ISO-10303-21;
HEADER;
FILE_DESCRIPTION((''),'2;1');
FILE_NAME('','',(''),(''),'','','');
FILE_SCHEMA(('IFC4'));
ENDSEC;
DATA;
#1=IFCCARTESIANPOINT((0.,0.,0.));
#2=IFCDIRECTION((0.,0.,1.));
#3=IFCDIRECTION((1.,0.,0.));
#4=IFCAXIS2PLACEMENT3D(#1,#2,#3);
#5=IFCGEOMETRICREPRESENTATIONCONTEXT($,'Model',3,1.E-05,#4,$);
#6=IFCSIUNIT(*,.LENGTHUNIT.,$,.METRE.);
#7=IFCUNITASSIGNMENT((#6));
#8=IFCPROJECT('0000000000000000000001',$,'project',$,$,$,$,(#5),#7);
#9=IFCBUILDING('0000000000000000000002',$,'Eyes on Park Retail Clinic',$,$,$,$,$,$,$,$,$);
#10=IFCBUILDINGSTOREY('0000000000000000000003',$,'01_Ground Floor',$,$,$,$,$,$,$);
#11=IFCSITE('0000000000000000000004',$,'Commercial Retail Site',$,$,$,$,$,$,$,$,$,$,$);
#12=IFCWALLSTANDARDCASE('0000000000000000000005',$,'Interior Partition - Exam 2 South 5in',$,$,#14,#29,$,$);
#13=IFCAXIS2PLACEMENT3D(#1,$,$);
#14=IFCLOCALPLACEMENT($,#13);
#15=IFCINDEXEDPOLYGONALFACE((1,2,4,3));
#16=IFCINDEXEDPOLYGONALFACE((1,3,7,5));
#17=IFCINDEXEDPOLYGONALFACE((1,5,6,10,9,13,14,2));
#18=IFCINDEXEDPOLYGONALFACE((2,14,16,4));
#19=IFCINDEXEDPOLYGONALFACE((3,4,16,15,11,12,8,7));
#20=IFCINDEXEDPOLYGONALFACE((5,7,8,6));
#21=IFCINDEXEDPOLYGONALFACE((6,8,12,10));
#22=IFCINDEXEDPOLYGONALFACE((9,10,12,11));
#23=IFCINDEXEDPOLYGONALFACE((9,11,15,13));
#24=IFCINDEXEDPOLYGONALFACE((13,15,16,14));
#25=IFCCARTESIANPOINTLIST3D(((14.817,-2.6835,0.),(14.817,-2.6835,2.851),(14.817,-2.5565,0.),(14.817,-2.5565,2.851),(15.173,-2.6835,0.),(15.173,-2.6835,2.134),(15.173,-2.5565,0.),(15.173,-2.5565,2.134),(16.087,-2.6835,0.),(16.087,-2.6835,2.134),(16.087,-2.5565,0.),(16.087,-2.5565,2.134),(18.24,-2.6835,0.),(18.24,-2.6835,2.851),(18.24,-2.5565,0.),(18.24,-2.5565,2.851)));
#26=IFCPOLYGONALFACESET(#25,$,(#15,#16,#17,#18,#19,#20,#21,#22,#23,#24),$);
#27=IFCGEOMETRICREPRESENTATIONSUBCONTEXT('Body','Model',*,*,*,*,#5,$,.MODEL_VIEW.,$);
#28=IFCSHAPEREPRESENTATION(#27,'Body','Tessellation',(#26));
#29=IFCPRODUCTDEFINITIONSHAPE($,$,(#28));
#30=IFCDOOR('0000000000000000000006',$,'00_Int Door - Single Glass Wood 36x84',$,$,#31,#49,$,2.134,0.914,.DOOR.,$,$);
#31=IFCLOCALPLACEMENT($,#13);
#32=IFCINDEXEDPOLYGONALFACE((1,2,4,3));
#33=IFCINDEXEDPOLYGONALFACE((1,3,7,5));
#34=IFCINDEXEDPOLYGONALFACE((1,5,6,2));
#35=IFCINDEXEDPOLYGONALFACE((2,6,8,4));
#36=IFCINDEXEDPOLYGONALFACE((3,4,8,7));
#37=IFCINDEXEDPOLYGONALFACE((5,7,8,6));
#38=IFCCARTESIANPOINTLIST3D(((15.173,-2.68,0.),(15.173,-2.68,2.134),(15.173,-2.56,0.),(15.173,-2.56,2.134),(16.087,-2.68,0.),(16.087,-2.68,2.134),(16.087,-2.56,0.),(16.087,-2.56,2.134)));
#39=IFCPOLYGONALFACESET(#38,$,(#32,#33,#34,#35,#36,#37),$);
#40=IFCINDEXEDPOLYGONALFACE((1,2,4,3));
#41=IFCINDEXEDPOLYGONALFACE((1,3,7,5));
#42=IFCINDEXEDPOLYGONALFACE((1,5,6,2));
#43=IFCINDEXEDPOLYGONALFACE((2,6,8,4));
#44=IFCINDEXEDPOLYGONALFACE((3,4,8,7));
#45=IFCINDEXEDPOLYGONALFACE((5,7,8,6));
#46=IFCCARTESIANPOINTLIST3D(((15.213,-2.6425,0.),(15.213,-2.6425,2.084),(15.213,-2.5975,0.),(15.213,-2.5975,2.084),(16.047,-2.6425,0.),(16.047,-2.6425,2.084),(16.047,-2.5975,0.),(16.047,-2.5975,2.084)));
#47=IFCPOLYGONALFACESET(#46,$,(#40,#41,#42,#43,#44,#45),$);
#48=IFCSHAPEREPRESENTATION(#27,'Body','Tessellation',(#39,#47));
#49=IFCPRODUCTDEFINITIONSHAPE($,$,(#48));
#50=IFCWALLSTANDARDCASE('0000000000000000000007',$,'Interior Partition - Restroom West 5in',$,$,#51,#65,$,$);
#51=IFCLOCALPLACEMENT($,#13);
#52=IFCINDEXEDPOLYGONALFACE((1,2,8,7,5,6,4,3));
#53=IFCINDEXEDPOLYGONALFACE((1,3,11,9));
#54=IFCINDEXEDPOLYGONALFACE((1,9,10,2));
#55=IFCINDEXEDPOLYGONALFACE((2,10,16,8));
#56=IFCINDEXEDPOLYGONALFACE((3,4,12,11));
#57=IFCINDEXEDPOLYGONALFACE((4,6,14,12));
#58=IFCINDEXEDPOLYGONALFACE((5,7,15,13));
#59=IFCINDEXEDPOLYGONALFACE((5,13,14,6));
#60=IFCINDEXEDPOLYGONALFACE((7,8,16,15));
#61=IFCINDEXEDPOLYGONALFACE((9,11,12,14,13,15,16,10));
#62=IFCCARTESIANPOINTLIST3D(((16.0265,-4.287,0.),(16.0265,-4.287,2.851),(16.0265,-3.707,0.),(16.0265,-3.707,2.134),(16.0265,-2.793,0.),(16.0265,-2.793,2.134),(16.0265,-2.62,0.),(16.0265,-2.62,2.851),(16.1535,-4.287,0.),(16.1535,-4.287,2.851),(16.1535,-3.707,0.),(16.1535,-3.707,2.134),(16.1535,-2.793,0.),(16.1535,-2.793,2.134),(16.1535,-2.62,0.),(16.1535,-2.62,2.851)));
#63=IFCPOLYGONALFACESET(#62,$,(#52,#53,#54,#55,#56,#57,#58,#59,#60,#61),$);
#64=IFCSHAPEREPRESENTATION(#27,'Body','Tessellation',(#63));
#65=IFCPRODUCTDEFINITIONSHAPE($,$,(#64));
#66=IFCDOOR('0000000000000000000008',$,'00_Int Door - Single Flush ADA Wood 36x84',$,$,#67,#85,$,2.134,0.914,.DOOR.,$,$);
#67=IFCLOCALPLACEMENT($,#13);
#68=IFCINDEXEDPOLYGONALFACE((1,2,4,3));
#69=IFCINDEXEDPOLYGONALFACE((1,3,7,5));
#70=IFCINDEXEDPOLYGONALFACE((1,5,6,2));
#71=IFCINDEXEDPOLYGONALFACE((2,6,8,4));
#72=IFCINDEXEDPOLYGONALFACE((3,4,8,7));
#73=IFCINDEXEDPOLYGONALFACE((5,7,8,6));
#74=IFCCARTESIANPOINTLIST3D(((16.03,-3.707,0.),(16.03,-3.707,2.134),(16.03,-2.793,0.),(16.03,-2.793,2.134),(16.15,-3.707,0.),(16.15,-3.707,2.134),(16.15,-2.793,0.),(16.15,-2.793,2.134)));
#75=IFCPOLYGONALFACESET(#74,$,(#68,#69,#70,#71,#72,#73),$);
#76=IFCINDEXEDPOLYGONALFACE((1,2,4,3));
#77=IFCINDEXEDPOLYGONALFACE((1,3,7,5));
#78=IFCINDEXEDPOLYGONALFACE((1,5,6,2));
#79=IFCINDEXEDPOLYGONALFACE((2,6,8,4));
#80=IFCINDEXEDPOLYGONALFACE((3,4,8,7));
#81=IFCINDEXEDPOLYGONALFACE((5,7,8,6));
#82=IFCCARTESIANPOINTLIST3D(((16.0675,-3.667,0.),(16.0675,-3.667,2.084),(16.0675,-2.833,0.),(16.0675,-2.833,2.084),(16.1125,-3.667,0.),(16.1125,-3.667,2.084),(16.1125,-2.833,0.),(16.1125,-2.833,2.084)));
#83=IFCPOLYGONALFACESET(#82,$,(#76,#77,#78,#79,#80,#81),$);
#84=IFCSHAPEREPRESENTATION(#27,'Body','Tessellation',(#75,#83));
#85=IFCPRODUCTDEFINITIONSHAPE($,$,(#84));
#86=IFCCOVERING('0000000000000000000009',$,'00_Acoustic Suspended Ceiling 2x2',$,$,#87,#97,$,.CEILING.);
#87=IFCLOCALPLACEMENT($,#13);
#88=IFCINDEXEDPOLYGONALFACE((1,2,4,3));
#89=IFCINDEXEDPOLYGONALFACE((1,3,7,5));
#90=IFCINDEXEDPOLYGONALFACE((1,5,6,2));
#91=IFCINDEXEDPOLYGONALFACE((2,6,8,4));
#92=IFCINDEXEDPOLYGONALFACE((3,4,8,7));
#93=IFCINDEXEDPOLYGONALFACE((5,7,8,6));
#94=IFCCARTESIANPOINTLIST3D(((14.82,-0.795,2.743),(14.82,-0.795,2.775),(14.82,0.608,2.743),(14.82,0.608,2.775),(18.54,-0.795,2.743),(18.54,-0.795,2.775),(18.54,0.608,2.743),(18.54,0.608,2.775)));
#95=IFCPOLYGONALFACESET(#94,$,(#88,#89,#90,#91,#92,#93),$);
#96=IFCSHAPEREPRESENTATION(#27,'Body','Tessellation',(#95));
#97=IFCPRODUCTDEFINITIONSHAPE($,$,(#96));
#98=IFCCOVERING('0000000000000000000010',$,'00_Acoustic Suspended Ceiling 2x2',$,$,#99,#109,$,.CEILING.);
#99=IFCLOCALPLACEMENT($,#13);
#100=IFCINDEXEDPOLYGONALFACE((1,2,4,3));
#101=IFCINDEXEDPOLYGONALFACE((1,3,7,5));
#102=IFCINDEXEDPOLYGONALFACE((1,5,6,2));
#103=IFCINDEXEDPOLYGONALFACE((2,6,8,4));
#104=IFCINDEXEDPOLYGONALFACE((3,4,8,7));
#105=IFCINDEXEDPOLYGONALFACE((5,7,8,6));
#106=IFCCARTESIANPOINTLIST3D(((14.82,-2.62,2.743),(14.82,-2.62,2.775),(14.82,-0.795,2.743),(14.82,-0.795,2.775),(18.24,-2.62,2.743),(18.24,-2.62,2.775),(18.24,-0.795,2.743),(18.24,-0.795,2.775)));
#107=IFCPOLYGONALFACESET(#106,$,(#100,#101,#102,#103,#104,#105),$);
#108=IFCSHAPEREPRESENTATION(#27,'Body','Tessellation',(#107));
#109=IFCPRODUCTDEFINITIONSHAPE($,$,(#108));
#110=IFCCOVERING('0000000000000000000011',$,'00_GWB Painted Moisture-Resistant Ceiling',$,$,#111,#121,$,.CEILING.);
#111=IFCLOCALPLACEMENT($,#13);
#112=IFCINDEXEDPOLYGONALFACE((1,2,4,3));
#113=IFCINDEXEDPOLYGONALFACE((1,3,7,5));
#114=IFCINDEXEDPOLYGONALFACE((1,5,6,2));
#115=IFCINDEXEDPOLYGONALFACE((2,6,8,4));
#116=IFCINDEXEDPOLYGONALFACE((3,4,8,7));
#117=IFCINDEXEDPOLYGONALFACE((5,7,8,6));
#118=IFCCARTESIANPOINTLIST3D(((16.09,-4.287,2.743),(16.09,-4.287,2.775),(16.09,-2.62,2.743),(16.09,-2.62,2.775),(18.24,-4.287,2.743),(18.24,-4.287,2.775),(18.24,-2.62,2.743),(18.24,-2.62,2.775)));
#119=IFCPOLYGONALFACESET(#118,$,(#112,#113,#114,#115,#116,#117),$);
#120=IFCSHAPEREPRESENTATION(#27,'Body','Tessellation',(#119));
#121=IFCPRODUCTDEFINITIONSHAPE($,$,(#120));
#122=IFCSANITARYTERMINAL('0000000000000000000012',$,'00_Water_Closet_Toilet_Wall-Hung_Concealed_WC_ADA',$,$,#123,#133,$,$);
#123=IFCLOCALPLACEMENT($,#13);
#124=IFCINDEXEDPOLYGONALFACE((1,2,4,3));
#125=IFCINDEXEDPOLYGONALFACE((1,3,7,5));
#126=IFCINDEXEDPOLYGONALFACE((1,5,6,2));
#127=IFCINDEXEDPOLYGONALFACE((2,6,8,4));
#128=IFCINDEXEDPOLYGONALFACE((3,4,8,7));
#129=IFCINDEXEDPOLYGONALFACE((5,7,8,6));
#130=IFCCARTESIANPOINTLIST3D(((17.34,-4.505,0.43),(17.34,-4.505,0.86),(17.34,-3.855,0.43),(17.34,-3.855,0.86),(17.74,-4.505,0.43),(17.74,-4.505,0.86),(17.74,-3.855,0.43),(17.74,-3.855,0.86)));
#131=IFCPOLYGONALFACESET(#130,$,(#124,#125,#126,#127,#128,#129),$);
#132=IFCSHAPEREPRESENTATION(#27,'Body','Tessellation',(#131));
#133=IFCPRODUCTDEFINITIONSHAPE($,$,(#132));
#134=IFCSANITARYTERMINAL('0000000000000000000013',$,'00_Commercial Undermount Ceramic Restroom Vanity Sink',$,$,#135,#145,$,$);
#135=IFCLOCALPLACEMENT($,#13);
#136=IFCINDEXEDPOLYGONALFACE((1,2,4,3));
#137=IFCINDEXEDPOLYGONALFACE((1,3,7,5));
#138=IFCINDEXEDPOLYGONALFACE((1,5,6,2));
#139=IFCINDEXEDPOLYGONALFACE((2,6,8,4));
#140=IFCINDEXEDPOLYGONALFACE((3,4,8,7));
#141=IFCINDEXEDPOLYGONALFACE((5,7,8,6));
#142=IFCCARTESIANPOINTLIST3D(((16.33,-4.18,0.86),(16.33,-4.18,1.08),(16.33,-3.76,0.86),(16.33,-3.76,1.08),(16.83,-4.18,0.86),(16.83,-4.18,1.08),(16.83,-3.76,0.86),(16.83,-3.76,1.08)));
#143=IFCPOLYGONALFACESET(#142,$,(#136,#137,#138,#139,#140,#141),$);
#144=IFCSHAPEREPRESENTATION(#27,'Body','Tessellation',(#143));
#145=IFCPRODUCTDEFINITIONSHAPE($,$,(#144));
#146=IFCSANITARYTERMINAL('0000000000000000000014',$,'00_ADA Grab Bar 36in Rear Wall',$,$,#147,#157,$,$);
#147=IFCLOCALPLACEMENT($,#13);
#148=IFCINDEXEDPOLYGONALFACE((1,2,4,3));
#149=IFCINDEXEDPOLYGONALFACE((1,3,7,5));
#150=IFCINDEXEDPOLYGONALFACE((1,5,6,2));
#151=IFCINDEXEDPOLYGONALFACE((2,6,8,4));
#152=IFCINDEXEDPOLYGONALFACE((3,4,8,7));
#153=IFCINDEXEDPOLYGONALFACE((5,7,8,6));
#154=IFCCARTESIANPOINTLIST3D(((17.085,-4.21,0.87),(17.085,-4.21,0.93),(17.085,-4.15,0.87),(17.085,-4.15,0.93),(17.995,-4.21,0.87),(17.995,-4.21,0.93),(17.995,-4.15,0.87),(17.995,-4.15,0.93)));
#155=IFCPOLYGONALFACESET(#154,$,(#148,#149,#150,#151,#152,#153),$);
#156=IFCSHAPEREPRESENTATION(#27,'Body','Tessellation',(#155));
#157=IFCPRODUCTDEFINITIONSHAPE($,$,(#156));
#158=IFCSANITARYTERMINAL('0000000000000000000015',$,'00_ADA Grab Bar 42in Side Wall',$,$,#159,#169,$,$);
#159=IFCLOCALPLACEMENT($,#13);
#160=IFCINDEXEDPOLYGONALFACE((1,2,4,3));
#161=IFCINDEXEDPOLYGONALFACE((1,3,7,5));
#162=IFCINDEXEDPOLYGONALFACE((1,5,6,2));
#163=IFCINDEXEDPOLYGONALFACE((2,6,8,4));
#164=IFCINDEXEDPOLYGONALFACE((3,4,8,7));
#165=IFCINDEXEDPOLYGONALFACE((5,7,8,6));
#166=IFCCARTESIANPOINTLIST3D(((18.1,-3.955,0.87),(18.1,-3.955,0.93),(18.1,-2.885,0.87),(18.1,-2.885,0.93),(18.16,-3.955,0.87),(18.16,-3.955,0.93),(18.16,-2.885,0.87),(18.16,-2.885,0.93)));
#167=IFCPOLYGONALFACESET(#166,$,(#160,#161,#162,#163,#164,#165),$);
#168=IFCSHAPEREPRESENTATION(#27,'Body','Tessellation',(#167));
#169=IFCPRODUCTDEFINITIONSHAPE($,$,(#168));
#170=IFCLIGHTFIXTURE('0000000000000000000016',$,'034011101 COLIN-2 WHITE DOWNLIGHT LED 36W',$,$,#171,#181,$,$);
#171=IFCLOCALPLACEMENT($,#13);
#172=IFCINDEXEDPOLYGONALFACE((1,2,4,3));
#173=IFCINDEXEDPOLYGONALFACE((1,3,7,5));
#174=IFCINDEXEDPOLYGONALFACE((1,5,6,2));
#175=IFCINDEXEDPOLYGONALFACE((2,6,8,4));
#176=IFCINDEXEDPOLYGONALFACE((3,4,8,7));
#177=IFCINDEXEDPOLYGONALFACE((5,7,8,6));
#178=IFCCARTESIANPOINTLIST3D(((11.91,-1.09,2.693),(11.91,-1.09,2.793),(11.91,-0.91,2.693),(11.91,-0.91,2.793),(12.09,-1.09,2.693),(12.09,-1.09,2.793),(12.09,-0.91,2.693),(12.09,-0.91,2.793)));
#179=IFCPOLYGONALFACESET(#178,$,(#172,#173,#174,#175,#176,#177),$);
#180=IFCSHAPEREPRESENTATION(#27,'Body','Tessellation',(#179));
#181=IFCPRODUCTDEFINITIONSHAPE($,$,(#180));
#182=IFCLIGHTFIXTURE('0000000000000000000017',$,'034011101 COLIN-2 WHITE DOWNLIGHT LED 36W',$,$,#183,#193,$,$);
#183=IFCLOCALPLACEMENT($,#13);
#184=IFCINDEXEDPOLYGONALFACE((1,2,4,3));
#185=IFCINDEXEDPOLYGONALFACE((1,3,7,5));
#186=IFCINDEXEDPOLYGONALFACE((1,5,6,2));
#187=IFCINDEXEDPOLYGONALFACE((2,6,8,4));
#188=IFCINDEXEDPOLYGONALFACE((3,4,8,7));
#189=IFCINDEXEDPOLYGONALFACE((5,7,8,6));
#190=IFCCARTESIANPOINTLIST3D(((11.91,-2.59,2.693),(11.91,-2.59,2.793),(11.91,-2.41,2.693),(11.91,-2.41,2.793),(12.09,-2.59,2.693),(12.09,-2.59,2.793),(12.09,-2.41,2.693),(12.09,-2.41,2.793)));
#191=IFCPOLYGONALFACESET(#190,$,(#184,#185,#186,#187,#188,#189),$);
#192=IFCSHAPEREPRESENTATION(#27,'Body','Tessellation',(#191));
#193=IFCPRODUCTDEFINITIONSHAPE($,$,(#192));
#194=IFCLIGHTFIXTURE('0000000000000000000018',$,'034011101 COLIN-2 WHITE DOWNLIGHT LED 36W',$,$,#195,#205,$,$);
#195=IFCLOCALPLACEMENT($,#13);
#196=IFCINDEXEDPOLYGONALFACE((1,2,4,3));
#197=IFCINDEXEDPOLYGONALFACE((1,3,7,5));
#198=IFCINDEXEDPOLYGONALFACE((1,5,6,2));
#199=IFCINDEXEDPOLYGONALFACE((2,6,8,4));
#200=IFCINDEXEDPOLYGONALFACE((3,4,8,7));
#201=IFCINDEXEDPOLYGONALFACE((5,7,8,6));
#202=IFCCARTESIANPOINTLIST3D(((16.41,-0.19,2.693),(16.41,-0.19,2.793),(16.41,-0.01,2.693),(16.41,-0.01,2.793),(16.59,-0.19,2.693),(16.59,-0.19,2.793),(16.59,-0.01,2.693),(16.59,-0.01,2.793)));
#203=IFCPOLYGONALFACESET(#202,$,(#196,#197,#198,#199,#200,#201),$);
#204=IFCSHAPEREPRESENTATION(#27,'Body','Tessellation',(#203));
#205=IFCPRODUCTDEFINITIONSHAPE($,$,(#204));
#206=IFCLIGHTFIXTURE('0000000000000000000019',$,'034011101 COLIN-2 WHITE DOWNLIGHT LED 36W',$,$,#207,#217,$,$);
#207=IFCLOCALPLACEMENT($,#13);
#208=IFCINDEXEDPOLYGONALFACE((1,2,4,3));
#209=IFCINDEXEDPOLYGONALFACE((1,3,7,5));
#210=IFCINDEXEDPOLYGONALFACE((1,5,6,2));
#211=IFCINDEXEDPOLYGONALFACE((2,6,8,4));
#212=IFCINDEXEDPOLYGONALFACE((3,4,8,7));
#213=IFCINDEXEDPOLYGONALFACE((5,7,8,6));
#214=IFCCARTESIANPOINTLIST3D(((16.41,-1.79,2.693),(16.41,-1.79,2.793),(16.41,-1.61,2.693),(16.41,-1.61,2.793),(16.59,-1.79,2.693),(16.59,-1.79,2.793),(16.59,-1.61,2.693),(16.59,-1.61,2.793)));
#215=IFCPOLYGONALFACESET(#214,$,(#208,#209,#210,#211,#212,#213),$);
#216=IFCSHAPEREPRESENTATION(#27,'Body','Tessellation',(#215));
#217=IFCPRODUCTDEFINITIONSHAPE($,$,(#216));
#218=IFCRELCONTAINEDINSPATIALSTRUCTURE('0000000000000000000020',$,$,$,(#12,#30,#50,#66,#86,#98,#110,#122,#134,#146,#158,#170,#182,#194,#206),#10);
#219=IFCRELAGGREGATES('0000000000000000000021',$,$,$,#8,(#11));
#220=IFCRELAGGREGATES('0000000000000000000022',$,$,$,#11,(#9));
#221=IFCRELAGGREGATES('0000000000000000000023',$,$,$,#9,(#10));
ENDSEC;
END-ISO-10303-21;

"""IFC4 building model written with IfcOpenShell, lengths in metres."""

from ifc_helpers import new_model, si_unit, frame, origin, origin_with_axes, place, context, subcontext, project, spatial, rectangle, extrude, element, fill, save


model = new_model("IFC4")

# Units and contexts
model_context = context("Model", 3, precision=1e-05, world=origin_with_axes())
body_context = subcontext(model_context, "Body", "Model", "MODEL_VIEW")
ifc_project = project(units=[si_unit("LENGTHUNIT", "METRE")], contexts=[model_context])

# Site, building, storey
site = spatial("IfcSite", under=ifc_project, Name="Commercial Retail Site")
building = spatial("IfcBuilding", under=site, Name="Eyes on Park Retail Clinic")
storey = spatial("IfcBuildingStorey", under=building, Name="01_Ground Floor")

# Walls, openings, doors
wall_1_placement = place(None, frame((16.5285, -2.62, 0.0), z_axis=(0.0, 0.0, 1.0), x_axis=(1.0, 0.0, 0.0)))
wall_1 = element("IfcWallStandardCase", 1, at=wall_1_placement, inside=storey, Name="Interior Partition - Exam 2 South 5in", context=body_context, shape_type="SweptSolid", body=[
    extrude(rectangle(XDim=3.423, YDim=0.127), origin(), (0.0, 0.0, 1.0), 2.851),
])
opening_1_placement = place(None, frame((15.63, -2.62, 0.0), z_axis=(0.0, 0.0, 1.0), x_axis=(1.0, 0.0, 0.0)))
opening_1 = element("IfcOpeningElement", 2, at=opening_1_placement, cuts=wall_1, context=body_context, shape_type="SweptSolid", body=[
    extrude(rectangle(XDim=0.914, YDim=0.227), origin(), (0.0, 0.0, 1.0), 2.134),
])
door_1_placement = place(opening_1_placement, origin_with_axes())
door_1 = element("IfcDoor", 3, at=door_1_placement, inside=storey, Name="00_Int Door - Single Glass Wood 36x84", OverallHeight=2.134, OverallWidth=0.914, PredefinedType="DOOR", context=body_context, shape_type="SweptSolid", body=[
    extrude(rectangle(XDim=0.914, YDim=0.12), origin(), (0.0, 0.0, 1.0), 2.134),
    extrude(rectangle(XDim=0.834, YDim=0.045), origin(), (0.0, 0.0, 1.0), 2.084),
])
fill(opening_1, door_1)
wall_2_placement = place(None, frame((16.09, -3.4535, 0.0), z_axis=(0.0, 0.0, 1.0), x_axis=(0.0, -1.0, 0.0)))
wall_2 = element("IfcWallStandardCase", 4, at=wall_2_placement, inside=storey, Name="Interior Partition - Restroom West 5in", context=body_context, shape_type="SweptSolid", body=[
    extrude(rectangle(XDim=1.667, YDim=0.127), origin(), (0.0, 0.0, 1.0), 2.851),
])
opening_2_placement = place(None, frame((16.09, -3.25, 0.0), z_axis=(0.0, 0.0, 1.0), x_axis=(0.0, -1.0, 0.0)))
opening_2 = element("IfcOpeningElement", 5, at=opening_2_placement, cuts=wall_2, context=body_context, shape_type="SweptSolid", body=[
    extrude(rectangle(XDim=0.914, YDim=0.227), origin(), (0.0, 0.0, 1.0), 2.134),
])
door_2_placement = place(opening_2_placement, origin_with_axes())
door_2 = element("IfcDoor", 6, at=door_2_placement, inside=storey, Name="00_Int Door - Single Flush ADA Wood 36x84", OverallHeight=2.134, OverallWidth=0.914, PredefinedType="DOOR", context=body_context, shape_type="SweptSolid", body=[
    extrude(rectangle(XDim=0.914, YDim=0.12), origin(), (0.0, 0.0, 1.0), 2.134),
    extrude(rectangle(XDim=0.834, YDim=0.045), origin(), (0.0, 0.0, 1.0), 2.084),
])
fill(opening_2, door_2)

# Coverings
covering_1_placement = place(None, frame((16.68, -0.0935, 2.743), z_axis=(0.0, 0.0, 1.0), x_axis=(1.0, 0.0, 0.0)))
element("IfcCovering", 7, at=covering_1_placement, inside=storey, Name="00_Acoustic Suspended Ceiling 2x2", PredefinedType="CEILING", context=body_context, shape_type="SweptSolid", body=[
    extrude(rectangle(XDim=3.72, YDim=1.403), origin(), (0.0, 0.0, 1.0), 0.032),
])
covering_2_placement = place(None, frame((16.53, -1.7075, 2.743), z_axis=(0.0, 0.0, 1.0), x_axis=(1.0, 0.0, 0.0)))
element("IfcCovering", 8, at=covering_2_placement, inside=storey, Name="00_Acoustic Suspended Ceiling 2x2", PredefinedType="CEILING", context=body_context, shape_type="SweptSolid", body=[
    extrude(rectangle(XDim=3.42, YDim=1.825), origin(), (0.0, 0.0, 1.0), 0.032),
])
covering_3_placement = place(None, frame((17.165, -3.4535, 2.743), z_axis=(0.0, 0.0, 1.0), x_axis=(1.0, 0.0, 0.0)))
element("IfcCovering", 9, at=covering_3_placement, inside=storey, Name="00_GWB Painted Moisture-Resistant Ceiling", PredefinedType="CEILING", context=body_context, shape_type="SweptSolid", body=[
    extrude(rectangle(XDim=2.15, YDim=1.667), origin(), (0.0, 0.0, 1.0), 0.032),
])

# Sanitary terminals
sanitary_terminal_1_placement = place(None, frame((17.54, -4.18, 0.43), z_axis=(0.0, 0.0, 1.0), x_axis=(1.0, 0.0, 0.0)))
element("IfcSanitaryTerminal", 10, at=sanitary_terminal_1_placement, inside=storey, Name="00_Water_Closet_Toilet_Wall-Hung_Concealed_WC_ADA", context=body_context, shape_type="SweptSolid", body=[
    extrude(rectangle(XDim=0.4, YDim=0.65), origin(), (0.0, 0.0, 1.0), 0.43),
])
sanitary_terminal_2_placement = place(None, frame((16.58, -3.97, 0.86), z_axis=(0.0, 0.0, 1.0), x_axis=(1.0, 0.0, 0.0)))
element("IfcSanitaryTerminal", 11, at=sanitary_terminal_2_placement, inside=storey, Name="00_Commercial Undermount Ceramic Restroom Vanity Sink", context=body_context, shape_type="SweptSolid", body=[
    extrude(rectangle(XDim=0.5, YDim=0.42), origin(), (0.0, 0.0, 1.0), 0.22),
])
sanitary_terminal_3_placement = place(None, frame((17.54, -4.18, 0.87), z_axis=(0.0, 0.0, 1.0), x_axis=(1.0, 0.0, 0.0)))
element("IfcSanitaryTerminal", 12, at=sanitary_terminal_3_placement, inside=storey, Name="00_ADA Grab Bar 36in Rear Wall", context=body_context, shape_type="SweptSolid", body=[
    extrude(rectangle(XDim=0.91, YDim=0.06), origin(), (0.0, 0.0, 1.0), 0.06),
])
sanitary_terminal_4_placement = place(None, frame((18.13, -3.42, 0.87), z_axis=(0.0, 0.0, 1.0), x_axis=(1.0, 0.0, 0.0)))
element("IfcSanitaryTerminal", 13, at=sanitary_terminal_4_placement, inside=storey, Name="00_ADA Grab Bar 42in Side Wall", context=body_context, shape_type="SweptSolid", body=[
    extrude(rectangle(XDim=0.06, YDim=1.07), origin(), (0.0, 0.0, 1.0), 0.06),
])

# Light fixtures
for number, where, z_axis, x_axis, name in (
    (14, (12.0, -1.0, 2.693), (0.0, 0.0, 1.0), (1.0, 0.0, 0.0), "034011101 COLIN-2 WHITE DOWNLIGHT LED 36W"),
    (15, (12.0, -2.5, 2.693), (0.0, 0.0, 1.0), (1.0, 0.0, 0.0), "034011101 COLIN-2 WHITE DOWNLIGHT LED 36W"),
    (16, (16.5, -0.1, 2.693), (0.0, 0.0, 1.0), (1.0, 0.0, 0.0), "034011101 COLIN-2 WHITE DOWNLIGHT LED 36W"),
    (17, (16.5, -1.7, 2.693), (0.0, 0.0, 1.0), (1.0, 0.0, 0.0), "034011101 COLIN-2 WHITE DOWNLIGHT LED 36W"),
):
    element("IfcLightFixture", number, at=place(None, frame(where, z_axis=z_axis, x_axis=x_axis)), inside=storey, Name=name, context=body_context, shape_type="SweptSolid", body=[
        extrude(rectangle(XDim=0.18, YDim=0.18), origin(), (0.0, 0.0, 1.0), 0.1),
    ])

save(model, "model.ifc")
